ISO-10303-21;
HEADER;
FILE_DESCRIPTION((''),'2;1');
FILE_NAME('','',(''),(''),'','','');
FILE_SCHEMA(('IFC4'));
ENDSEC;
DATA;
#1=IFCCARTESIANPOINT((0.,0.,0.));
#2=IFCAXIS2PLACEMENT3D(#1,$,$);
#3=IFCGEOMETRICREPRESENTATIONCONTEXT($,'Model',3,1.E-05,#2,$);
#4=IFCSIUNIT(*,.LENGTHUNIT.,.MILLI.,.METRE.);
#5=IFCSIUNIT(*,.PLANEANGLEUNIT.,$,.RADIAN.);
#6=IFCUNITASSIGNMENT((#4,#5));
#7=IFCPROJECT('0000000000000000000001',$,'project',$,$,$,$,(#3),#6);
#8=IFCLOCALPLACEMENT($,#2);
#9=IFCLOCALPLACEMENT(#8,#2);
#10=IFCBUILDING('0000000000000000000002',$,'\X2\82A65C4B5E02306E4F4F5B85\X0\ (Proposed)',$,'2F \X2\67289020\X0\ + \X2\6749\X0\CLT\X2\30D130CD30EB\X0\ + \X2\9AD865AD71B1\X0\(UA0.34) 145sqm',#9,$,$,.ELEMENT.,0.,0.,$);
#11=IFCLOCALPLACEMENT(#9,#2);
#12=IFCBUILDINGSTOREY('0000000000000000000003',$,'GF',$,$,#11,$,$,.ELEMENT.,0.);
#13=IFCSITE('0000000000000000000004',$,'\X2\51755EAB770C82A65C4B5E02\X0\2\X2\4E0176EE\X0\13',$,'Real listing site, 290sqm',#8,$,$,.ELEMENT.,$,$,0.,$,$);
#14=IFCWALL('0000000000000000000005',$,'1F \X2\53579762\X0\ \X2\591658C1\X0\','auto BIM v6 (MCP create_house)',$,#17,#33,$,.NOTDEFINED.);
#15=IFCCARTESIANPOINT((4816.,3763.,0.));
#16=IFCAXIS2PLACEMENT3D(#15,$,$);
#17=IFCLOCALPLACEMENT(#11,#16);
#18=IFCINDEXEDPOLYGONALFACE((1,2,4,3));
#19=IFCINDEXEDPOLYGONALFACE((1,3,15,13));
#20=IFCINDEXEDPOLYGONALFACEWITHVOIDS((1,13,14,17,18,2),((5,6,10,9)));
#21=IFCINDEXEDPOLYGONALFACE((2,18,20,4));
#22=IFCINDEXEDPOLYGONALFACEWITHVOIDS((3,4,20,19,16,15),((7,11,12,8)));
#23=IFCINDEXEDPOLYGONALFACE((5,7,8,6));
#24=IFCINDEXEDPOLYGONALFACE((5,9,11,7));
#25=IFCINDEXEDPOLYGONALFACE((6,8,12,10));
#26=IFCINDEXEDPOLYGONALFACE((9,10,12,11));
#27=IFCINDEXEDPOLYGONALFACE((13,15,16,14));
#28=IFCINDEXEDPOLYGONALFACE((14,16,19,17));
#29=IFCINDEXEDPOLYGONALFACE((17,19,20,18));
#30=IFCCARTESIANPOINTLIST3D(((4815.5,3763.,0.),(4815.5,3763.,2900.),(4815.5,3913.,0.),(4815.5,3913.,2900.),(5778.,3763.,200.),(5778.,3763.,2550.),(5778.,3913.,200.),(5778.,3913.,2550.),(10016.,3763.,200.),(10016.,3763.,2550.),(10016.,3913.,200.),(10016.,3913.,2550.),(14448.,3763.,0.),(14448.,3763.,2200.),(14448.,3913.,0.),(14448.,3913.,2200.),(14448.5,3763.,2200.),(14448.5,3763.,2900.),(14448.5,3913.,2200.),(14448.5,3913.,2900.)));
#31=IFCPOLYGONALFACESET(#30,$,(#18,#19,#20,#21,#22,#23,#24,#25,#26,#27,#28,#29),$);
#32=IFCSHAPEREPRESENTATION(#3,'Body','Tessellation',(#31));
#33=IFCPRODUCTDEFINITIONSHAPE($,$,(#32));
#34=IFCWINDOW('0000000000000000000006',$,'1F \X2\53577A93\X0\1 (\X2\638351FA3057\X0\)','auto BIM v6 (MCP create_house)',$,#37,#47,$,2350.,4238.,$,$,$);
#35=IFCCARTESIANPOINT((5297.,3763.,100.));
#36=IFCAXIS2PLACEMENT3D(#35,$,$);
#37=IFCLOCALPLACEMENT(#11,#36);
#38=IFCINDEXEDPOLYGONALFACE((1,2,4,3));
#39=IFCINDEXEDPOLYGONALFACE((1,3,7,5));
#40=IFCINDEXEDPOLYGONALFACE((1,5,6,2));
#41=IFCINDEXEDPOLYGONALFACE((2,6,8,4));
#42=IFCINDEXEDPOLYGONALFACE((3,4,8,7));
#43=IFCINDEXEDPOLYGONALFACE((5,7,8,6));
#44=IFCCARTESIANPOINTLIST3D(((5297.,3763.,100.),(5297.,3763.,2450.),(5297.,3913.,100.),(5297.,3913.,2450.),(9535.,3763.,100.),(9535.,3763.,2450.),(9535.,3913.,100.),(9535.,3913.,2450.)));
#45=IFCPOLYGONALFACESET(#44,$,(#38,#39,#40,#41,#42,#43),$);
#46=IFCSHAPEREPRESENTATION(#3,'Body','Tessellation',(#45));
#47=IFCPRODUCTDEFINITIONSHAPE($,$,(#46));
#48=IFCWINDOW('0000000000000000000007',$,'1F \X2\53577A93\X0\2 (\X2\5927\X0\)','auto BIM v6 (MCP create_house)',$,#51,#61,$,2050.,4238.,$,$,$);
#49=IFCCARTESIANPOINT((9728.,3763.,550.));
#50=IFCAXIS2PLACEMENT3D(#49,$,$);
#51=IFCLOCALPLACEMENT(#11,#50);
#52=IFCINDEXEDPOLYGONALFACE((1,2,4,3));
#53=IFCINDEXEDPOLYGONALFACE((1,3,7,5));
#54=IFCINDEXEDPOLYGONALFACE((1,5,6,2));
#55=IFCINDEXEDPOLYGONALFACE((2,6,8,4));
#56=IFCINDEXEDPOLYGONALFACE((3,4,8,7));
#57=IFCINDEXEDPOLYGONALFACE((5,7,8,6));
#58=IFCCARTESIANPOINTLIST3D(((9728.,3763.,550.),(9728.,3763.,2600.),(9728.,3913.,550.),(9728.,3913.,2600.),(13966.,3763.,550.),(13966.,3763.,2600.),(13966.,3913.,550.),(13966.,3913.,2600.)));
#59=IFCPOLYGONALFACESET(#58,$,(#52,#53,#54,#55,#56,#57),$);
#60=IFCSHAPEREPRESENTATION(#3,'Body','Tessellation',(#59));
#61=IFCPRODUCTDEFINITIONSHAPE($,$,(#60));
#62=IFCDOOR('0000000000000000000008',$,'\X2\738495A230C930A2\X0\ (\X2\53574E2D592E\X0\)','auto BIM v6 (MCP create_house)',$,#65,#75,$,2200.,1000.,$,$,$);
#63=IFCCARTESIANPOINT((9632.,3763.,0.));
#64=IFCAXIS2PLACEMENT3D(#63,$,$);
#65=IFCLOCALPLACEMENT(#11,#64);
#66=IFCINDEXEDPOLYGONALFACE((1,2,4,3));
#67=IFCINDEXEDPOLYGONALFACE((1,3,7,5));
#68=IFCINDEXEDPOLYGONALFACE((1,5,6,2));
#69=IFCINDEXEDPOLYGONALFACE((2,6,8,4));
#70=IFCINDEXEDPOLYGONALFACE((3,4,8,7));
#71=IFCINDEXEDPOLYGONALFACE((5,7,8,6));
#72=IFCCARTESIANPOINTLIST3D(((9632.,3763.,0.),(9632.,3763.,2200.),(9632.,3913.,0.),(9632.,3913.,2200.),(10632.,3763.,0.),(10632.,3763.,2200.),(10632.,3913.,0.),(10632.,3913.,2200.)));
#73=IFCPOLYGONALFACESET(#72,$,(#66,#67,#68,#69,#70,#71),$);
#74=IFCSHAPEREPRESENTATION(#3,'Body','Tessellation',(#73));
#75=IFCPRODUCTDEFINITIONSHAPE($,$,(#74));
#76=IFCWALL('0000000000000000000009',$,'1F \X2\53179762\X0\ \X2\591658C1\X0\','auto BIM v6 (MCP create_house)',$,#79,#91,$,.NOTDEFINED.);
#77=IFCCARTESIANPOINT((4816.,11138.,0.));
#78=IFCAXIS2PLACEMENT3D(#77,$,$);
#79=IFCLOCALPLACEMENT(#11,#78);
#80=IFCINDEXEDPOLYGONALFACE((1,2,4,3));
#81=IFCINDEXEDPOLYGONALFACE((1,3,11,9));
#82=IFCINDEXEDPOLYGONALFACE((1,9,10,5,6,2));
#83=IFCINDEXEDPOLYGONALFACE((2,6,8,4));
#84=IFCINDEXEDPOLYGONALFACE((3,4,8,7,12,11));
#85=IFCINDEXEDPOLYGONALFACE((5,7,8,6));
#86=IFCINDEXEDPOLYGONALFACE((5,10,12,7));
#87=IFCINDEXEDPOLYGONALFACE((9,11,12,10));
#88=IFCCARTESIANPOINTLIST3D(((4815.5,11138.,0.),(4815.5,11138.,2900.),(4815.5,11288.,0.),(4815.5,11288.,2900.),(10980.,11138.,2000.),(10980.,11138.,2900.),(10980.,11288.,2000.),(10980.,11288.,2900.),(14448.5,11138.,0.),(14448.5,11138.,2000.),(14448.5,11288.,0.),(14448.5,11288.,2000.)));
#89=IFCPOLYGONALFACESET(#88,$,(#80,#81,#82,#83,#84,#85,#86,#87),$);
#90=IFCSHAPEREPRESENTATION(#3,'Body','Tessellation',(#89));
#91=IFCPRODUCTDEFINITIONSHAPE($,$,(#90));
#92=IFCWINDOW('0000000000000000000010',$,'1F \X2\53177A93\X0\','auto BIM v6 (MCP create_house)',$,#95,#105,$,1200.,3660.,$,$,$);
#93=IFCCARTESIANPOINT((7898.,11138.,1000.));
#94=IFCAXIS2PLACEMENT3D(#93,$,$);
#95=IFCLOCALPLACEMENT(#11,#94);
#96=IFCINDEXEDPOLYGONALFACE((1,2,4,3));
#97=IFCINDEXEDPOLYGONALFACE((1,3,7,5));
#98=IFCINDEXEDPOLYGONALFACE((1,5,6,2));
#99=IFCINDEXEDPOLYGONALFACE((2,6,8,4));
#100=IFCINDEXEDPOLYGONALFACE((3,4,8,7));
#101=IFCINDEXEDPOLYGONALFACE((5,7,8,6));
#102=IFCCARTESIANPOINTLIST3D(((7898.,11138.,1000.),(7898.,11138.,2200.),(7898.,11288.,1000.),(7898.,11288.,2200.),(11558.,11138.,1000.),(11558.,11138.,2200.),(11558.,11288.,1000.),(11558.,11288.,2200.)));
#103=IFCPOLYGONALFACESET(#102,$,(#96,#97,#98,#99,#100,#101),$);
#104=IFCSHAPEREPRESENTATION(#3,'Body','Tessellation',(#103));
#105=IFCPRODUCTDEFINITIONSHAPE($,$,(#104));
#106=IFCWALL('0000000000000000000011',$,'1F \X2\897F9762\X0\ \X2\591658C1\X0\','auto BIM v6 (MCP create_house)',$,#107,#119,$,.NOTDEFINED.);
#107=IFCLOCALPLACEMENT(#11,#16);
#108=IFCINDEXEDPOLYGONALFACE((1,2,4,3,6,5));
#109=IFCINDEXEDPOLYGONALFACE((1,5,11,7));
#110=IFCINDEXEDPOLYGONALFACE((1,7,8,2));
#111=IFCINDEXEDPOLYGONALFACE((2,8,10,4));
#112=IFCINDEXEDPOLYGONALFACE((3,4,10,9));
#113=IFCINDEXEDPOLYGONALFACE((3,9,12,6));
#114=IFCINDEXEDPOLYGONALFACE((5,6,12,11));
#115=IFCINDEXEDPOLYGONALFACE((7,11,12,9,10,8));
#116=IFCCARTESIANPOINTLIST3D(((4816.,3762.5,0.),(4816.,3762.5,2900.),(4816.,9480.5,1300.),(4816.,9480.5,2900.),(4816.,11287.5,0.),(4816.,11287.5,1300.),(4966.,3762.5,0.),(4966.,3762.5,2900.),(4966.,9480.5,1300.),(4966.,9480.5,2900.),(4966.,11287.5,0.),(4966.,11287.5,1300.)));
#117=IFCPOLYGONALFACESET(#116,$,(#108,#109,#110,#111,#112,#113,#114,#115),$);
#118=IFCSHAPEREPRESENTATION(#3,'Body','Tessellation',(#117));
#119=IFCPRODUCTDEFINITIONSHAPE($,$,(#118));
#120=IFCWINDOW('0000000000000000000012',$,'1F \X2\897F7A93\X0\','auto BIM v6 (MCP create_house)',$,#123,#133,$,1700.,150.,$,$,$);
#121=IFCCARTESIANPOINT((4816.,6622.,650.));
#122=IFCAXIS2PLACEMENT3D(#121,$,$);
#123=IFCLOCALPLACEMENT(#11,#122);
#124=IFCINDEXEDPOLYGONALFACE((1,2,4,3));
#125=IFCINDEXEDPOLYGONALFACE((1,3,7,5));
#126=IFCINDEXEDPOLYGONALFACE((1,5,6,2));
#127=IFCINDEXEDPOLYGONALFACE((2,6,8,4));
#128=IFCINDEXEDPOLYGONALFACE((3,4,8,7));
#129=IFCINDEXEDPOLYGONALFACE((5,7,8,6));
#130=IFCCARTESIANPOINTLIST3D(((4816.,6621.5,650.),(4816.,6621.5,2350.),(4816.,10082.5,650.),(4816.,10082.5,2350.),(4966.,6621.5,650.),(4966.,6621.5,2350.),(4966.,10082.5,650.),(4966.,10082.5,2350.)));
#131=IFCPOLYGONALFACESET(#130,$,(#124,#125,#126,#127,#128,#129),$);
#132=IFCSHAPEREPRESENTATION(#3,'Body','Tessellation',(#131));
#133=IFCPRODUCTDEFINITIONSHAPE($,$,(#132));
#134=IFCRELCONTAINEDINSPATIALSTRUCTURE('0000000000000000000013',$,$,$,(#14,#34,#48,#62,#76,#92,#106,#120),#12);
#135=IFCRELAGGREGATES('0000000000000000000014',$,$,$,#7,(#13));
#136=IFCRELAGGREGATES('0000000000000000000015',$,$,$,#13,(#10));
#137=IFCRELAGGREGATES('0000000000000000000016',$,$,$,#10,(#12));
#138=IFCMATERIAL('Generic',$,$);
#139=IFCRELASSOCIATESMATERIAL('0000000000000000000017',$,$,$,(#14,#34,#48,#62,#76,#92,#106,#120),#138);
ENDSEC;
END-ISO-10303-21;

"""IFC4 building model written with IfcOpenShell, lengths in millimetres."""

from ifc_helpers import new_model, si_unit, frame, frame_2d, origin, place, context, project, spatial, rectangle, extrude, material, element, fill, save


model = new_model("IFC4")

# Units and contexts
model_context = context("Model", 3, precision=1e-05, world=origin())
ifc_project = project(units=[si_unit("LENGTHUNIT", "METRE", prefix="MILLI"), si_unit("PLANEANGLEUNIT", "RADIAN")], contexts=[model_context])

# Site, building, storey
site_placement = place(None, origin())
site = spatial("IfcSite", under=ifc_project, at=site_placement, Name="兵庫県芦屋市2丁目13", ObjectType="Real listing site, 290sqm", CompositionType="ELEMENT", RefElevation=0.0)
building_placement = place(site_placement, origin())
building = spatial("IfcBuilding", under=site, at=building_placement, Name="芦屋市の住宅 (Proposed)", ObjectType="2F 木造 + 杉CLTパネル + 高断熱(UA0.34) 145sqm", CompositionType="ELEMENT", ElevationOfRefHeight=0.0, ElevationOfTerrain=0.0)
storey_placement = place(building_placement, origin())
storey = spatial("IfcBuildingStorey", under=building, at=storey_placement, Name="GF", CompositionType="ELEMENT", Elevation=0.0)

# Shared definitions
ifc_material = material(Name="Generic")

# Wall, openings, windows, door
wall_1_placement = place(storey_placement, frame((4816.0, 3763.0, 0.0)))
wall_1 = element("IfcWall", 1, at=wall_1_placement, inside=storey, material=ifc_material, Name="1F 南面 外壁", Description="auto BIM v6 (MCP create_house)", PredefinedType="NOTDEFINED", context=model_context, shape_type="SweptSolid", body=[
    extrude(rectangle(XDim=9633.0, YDim=150.0, at=frame_2d((4816.0, 75.0))), frame((4816.0, 3763.0, 0.0)), (0.0, 0.0, 1.0), 2900.0),
])
opening_1_placement = place(storey_placement, frame((5297.0, 3763.0, 100.0)))
opening_1 = element("IfcOpeningElement", 2, at=opening_1_placement, cuts=wall_1, PredefinedType="NOTDEFINED", context=model_context, shape_type="SweptSolid", body=[
    extrude(rectangle(XDim=4238.0, YDim=150.0, at=frame_2d((2119.0, 75.0))), frame((5297.0, 3763.0, 100.0)), (0.0, 0.0, 1.0), 2350.0),
])
opening_2_placement = place(storey_placement, frame((9728.0, 3763.0, 550.0)))
opening_2 = element("IfcOpeningElement", 3, at=opening_2_placement, cuts=wall_1, PredefinedType="NOTDEFINED", context=model_context, shape_type="SweptSolid", body=[
    extrude(rectangle(XDim=4238.0, YDim=150.0, at=frame_2d((2119.0, 75.0))), frame((9728.0, 3763.0, 550.0)), (0.0, 0.0, 1.0), 2050.0),
])
opening_3_placement = place(storey_placement, frame((9632.0, 3763.0, 0.0)))
opening_3 = element("IfcOpeningElement", 4, at=opening_3_placement, cuts=wall_1, PredefinedType="NOTDEFINED", context=model_context, shape_type="SweptSolid", body=[
    extrude(rectangle(XDim=1000.0, YDim=150.0, at=frame_2d((500.0, 75.0))), frame((9632.0, 3763.0, 0.0)), (0.0, 0.0, 1.0), 2200.0),
])
window_1_placement = place(storey_placement, frame((5297.0, 3763.0, 100.0)))
window_1 = element("IfcWindow", 5, at=window_1_placement, inside=storey, material=ifc_material, Name="1F 南窓1 (掃出し)", Description="auto BIM v6 (MCP create_house)", OverallHeight=2350.0, OverallWidth=4238.0, context=model_context, shape_type="SweptSolid", body=[
    extrude(rectangle(XDim=4238.0, YDim=150.0, at=frame_2d((2119.0, 75.0))), frame((5297.0, 3763.0, 100.0)), (0.0, 0.0, 1.0), 2350.0),
])
fill(opening_1, window_1)
window_2_placement = place(storey_placement, frame((9728.0, 3763.0, 550.0)))
window_2 = element("IfcWindow", 6, at=window_2_placement, inside=storey, material=ifc_material, Name="1F 南窓2 (大)", Description="auto BIM v6 (MCP create_house)", OverallHeight=2050.0, OverallWidth=4238.0, context=model_context, shape_type="SweptSolid", body=[
    extrude(rectangle(XDim=4238.0, YDim=150.0, at=frame_2d((2119.0, 75.0))), frame((9728.0, 3763.0, 550.0)), (0.0, 0.0, 1.0), 2050.0),
])
fill(opening_2, window_2)
door_placement = place(storey_placement, frame((9632.0, 3763.0, 0.0)))
door = element("IfcDoor", 7, at=door_placement, inside=storey, material=ifc_material, Name="玄関ドア (南中央)", Description="auto BIM v6 (MCP create_house)", OverallHeight=2200.0, OverallWidth=1000.0, context=model_context, shape_type="SweptSolid", body=[
    extrude(rectangle(XDim=1000.0, YDim=150.0, at=frame_2d((500.0, 75.0))), frame((9632.0, 3763.0, 0.0)), (0.0, 0.0, 1.0), 2200.0),
])
fill(opening_3, door)

# Walls, openings, windows
wall_2_placement = place(storey_placement, frame((4816.0, 11138.0, 0.0)))
wall_2 = element("IfcWall", 8, at=wall_2_placement, inside=storey, material=ifc_material, Name="1F 北面 外壁", Description="auto BIM v6 (MCP create_house)", PredefinedType="NOTDEFINED", context=model_context, shape_type="SweptSolid", body=[
    extrude(rectangle(XDim=9633.0, YDim=150.0, at=frame_2d((4816.0, 75.0))), frame((4816.0, 11138.0, 0.0)), (0.0, 0.0, 1.0), 2900.0),
])
opening_4_placement = place(storey_placement, frame((7898.0, 11138.0, 1000.0)))
opening_4 = element("IfcOpeningElement", 9, at=opening_4_placement, cuts=wall_2, PredefinedType="NOTDEFINED", context=model_context, shape_type="SweptSolid", body=[
    extrude(rectangle(XDim=3660.0, YDim=150.0, at=frame_2d((1830.0, 75.0))), frame((7898.0, 11138.0, 1000.0)), (0.0, 0.0, 1.0), 1200.0),
])
window_3_placement = place(storey_placement, frame((7898.0, 11138.0, 1000.0)))
window_3 = element("IfcWindow", 10, at=window_3_placement, inside=storey, material=ifc_material, Name="1F 北窓", Description="auto BIM v6 (MCP create_house)", OverallHeight=1200.0, OverallWidth=3660.0, context=model_context, shape_type="SweptSolid", body=[
    extrude(rectangle(XDim=3660.0, YDim=150.0, at=frame_2d((1830.0, 75.0))), frame((7898.0, 11138.0, 1000.0)), (0.0, 0.0, 1.0), 1200.0),
])
fill(opening_4, window_3)
wall_3_placement = place(storey_placement, frame((4816.0, 3763.0, 0.0)))
wall_3 = element("IfcWall", 11, at=wall_3_placement, inside=storey, material=ifc_material, Name="1F 西面 外壁", Description="auto BIM v6 (MCP create_house)", PredefinedType="NOTDEFINED", context=model_context, shape_type="SweptSolid", body=[
    extrude(rectangle(XDim=150.0, YDim=7525.0, at=frame_2d((75.0, 3762.0))), frame((4816.0, 3763.0, 0.0)), (0.0, 0.0, 1.0), 2900.0),
])
opening_5_placement = place(storey_placement, frame((4816.0, 6622.0, 650.0)))
opening_5 = element("IfcOpeningElement", 12, at=opening_5_placement, cuts=wall_3, PredefinedType="NOTDEFINED", context=model_context, shape_type="SweptSolid", body=[
    extrude(rectangle(XDim=150.0, YDim=3461.0, at=frame_2d((75.0, 1730.0))), frame((4816.0, 6622.0, 650.0)), (0.0, 0.0, 1.0), 1700.0),
])
window_4_placement = place(storey_placement, frame((4816.0, 6622.0, 650.0)))
window_4 = element("IfcWindow", 13, at=window_4_placement, inside=storey, material=ifc_material, Name="1F 西窓", Description="auto BIM v6 (MCP create_house)", OverallHeight=1700.0, OverallWidth=150.0, context=model_context, shape_type="SweptSolid", body=[
    extrude(rectangle(XDim=150.0, YDim=3461.0, at=frame_2d((75.0, 1730.0))), frame((4816.0, 6622.0, 650.0)), (0.0, 0.0, 1.0), 1700.0),
])
fill(opening_5, window_4)

save(model, "model.ifc")
